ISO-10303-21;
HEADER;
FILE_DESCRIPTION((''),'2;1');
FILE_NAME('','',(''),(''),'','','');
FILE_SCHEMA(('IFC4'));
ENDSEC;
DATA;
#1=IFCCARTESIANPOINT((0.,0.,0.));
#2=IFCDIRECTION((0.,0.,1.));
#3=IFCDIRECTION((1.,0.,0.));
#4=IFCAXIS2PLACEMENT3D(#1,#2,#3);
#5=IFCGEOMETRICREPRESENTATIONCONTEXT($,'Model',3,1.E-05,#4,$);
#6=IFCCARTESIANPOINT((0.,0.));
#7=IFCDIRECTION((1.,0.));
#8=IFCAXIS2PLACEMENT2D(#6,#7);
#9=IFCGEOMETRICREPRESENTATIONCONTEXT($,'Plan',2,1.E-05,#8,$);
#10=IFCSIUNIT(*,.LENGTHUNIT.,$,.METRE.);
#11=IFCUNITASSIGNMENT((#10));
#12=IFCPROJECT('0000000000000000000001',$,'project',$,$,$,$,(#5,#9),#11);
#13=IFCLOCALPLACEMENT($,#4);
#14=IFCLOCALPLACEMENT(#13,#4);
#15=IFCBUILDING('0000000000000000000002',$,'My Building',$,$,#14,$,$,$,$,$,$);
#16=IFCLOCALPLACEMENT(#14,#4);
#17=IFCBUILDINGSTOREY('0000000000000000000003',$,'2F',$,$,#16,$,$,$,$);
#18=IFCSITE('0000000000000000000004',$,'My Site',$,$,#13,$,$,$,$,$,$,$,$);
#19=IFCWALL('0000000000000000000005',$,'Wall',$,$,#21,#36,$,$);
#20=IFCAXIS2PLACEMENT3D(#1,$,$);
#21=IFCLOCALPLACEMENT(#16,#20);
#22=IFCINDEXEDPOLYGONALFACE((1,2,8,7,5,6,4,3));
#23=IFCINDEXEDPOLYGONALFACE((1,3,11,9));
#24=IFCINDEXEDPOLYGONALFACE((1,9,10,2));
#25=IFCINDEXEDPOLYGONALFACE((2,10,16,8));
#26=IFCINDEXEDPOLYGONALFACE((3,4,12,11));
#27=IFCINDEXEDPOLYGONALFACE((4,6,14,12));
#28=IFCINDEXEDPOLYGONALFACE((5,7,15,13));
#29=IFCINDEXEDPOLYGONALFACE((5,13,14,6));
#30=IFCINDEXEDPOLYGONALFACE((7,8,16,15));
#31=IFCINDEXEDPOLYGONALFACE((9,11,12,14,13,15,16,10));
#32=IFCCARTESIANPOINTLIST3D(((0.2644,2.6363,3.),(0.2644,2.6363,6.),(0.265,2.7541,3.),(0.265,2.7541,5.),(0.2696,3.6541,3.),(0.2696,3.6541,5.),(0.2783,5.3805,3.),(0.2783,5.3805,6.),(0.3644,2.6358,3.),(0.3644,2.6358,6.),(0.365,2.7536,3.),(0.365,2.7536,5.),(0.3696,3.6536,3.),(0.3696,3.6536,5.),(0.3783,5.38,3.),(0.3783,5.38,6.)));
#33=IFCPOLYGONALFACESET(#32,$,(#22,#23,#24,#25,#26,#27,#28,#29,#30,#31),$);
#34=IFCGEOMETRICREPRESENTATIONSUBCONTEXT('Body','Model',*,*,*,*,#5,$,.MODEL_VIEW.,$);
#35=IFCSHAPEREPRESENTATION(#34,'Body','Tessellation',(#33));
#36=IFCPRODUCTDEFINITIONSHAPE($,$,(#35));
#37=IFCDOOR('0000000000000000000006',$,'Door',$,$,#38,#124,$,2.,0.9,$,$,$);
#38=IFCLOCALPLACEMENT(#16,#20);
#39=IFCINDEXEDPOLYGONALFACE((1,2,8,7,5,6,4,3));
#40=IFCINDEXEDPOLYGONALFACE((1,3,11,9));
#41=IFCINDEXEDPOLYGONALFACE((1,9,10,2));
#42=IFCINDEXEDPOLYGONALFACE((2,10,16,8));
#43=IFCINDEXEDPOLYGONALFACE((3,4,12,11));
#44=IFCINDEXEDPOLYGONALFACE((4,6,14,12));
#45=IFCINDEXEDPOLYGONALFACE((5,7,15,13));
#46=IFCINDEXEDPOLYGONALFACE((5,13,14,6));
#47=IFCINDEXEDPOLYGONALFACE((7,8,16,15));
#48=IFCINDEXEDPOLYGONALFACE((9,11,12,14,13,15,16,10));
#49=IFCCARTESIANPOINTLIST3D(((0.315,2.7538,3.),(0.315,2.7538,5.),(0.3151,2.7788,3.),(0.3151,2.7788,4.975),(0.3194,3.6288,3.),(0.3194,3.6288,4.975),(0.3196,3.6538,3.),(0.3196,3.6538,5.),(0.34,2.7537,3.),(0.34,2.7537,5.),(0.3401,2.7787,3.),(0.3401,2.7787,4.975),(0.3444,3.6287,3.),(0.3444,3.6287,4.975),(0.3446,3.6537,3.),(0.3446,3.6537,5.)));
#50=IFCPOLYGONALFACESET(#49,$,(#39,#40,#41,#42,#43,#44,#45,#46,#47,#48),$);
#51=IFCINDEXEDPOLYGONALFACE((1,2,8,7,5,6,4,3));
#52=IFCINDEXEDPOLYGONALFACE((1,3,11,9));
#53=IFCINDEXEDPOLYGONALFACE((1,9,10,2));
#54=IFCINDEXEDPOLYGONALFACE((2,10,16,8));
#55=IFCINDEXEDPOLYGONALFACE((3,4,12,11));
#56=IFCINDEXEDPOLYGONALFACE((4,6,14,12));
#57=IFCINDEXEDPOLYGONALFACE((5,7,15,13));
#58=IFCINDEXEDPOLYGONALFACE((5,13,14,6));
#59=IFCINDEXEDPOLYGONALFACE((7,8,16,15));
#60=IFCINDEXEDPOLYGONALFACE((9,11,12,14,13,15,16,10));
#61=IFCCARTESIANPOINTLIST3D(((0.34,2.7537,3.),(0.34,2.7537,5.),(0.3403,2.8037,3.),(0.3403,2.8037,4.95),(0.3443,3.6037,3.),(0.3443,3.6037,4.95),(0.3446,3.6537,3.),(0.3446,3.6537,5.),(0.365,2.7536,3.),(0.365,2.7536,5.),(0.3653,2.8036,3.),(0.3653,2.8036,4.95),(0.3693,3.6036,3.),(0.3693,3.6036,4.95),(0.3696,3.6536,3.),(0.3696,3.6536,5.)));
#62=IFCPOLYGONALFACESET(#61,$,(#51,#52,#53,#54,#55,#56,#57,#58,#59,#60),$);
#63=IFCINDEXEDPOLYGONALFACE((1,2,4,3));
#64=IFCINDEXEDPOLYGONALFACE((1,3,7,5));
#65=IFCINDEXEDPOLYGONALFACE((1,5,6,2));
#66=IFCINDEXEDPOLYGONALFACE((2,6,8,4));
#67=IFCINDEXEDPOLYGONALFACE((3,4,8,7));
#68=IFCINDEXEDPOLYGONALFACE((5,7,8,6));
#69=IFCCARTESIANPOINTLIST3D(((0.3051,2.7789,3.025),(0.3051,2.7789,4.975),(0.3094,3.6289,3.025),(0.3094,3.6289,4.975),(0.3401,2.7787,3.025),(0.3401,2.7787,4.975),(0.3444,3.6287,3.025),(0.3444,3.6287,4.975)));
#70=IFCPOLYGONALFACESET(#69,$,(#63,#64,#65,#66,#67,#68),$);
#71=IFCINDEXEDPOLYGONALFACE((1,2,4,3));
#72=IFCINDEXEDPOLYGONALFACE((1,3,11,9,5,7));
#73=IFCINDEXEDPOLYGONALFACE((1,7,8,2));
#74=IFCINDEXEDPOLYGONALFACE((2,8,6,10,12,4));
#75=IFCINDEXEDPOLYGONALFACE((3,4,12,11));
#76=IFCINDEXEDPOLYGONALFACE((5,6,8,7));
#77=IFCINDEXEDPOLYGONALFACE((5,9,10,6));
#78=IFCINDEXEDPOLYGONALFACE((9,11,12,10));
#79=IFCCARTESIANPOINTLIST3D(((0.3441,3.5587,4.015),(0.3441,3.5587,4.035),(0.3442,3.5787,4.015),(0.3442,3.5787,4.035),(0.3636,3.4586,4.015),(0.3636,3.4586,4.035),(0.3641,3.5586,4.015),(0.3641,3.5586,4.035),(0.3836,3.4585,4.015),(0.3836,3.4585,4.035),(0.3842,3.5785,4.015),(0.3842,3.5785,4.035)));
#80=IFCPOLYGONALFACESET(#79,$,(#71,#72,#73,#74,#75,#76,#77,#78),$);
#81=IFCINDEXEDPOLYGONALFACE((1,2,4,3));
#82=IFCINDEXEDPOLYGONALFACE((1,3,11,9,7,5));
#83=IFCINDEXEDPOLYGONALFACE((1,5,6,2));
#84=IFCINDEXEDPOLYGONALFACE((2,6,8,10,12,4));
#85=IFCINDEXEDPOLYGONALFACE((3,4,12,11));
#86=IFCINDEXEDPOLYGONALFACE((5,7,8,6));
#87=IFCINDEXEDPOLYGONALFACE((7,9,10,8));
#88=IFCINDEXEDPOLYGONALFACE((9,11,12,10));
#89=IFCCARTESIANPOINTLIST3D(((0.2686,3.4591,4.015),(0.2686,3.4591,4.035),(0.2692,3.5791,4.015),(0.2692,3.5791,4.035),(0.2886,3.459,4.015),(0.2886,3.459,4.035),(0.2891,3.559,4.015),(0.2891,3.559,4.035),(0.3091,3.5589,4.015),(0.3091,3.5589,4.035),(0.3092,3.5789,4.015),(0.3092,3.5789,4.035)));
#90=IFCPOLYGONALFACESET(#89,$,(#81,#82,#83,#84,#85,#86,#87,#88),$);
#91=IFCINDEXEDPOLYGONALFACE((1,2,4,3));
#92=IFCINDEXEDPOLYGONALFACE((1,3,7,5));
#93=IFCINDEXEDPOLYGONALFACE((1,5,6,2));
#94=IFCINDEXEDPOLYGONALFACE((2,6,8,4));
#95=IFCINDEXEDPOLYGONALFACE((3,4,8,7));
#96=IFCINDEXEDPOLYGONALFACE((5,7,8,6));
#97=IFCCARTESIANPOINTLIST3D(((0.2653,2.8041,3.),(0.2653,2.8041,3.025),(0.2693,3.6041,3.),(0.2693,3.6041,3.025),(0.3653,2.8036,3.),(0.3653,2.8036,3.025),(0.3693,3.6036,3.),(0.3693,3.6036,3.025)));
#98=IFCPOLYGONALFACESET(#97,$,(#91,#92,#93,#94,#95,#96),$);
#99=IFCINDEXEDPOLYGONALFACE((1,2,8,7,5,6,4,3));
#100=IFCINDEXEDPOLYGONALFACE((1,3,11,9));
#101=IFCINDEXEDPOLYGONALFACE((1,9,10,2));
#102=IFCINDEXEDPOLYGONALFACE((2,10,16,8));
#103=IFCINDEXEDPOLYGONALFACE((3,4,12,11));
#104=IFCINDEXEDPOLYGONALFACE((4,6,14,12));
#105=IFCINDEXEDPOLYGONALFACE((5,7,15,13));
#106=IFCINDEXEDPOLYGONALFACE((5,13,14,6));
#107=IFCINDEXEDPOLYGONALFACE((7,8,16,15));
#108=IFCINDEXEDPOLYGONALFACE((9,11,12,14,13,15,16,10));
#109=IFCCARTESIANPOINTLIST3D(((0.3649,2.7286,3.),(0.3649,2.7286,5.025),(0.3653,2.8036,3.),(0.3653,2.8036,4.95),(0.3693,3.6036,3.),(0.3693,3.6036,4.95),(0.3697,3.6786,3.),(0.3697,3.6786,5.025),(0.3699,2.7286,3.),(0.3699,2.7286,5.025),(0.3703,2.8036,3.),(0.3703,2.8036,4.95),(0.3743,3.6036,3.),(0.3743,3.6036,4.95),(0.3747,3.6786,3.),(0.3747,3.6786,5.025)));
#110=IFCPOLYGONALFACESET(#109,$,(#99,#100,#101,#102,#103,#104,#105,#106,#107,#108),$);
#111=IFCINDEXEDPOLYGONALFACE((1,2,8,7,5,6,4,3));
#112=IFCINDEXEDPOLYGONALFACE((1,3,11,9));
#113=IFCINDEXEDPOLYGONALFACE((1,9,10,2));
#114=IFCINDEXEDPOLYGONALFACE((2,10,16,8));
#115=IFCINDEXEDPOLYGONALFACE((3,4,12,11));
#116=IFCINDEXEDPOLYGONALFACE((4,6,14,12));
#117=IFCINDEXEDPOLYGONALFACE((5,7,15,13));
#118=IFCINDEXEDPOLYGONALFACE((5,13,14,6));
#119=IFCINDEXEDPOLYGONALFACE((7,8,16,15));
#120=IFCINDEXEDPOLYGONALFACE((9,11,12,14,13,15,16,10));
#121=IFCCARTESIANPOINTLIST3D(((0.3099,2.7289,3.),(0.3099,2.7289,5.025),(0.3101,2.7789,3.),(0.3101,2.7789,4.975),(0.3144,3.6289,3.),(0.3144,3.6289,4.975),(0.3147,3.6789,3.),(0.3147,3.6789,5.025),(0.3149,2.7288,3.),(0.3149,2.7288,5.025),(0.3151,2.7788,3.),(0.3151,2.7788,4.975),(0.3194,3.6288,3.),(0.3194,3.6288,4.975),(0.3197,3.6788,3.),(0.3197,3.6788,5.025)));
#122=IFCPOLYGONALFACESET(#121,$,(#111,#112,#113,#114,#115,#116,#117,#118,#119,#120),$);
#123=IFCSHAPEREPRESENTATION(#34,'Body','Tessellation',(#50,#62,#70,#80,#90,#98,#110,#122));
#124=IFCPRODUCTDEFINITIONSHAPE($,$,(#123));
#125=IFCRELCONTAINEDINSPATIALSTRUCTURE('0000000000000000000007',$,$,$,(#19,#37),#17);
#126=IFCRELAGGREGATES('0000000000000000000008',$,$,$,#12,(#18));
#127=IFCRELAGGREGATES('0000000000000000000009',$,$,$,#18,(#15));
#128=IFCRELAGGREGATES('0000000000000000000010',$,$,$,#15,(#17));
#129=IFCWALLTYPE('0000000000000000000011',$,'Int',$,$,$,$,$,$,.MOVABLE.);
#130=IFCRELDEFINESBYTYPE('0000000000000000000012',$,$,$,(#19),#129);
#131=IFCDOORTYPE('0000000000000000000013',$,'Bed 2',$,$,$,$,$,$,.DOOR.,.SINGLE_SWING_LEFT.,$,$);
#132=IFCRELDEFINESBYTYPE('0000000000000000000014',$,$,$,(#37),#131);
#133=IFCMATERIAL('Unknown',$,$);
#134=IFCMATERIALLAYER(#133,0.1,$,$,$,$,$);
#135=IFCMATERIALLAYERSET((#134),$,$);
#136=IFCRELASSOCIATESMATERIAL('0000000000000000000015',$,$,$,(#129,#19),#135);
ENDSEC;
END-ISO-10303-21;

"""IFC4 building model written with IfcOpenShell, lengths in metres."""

from ifc_helpers import new_model, entity, si_unit, frame, origin_with_axes, origin_2d_with_axis, place, context, subcontext, project, spatial, line, indexed_curve, outline, extrude, shape, source, transform, mapped, material, layer, layer_set, layer_usage, type_object, type_shapes, element, fill, save


model = new_model("IFC4")

# Units and contexts
model_context = context("Model", 3, precision=1e-05, world=origin_with_axes())
plan_context = context("Plan", 2, precision=1e-05, world=origin_2d_with_axis())
body_context_1 = subcontext(model_context, "Body", "Model", "MODEL_VIEW")
body_context_2 = subcontext(plan_context, "Body", "Plan", "PLAN_VIEW")
ifc_project = project(units=[si_unit("LENGTHUNIT", "METRE")], contexts=[model_context, plan_context])

# Site, building, storey
site_placement = place(None, origin_with_axes())
site = spatial("IfcSite", under=ifc_project, at=site_placement, Name="My Site")
building_placement = place(site_placement, origin_with_axes())
building = spatial("IfcBuilding", under=site, at=building_placement, Name="My Building")
storey_placement = place(building_placement, origin_with_axes())
storey = spatial("IfcBuildingStorey", under=building, at=storey_placement, Name="2F")

# Shared definitions
ifc_material = material(Name="Unknown")

# Shared definitions
ifc_layer_1 = layer(ifc_material, 0.1)
ifc_layer_set_1 = layer_set([ifc_layer_1])
wall_type_1 = type_object("IfcWallType", Name="Int", PredefinedType="MOVABLE", material=ifc_layer_set_1)

# Wall, opening, door
ifc_layer_usage_1 = layer_usage(ifc_layer_set_1, "AXIS2", "POSITIVE", 0.0)
wall_1_placement = place(storey_placement, frame((0.3644, 2.6358, 3.0), z_axis=(0.0, 0.0, 1.0), x_axis=(0.005081, 0.999987, 0.0)))
wall_1 = element("IfcWall", 1, at=wall_1_placement, inside=storey, type_object=wall_type_1, material=ifc_layer_usage_1, Name="Wall", context=body_context_1, shape_type="SweptSolid", body=[
    extrude(outline(indexed_curve([(0.0, 0.0), (0.0, 0.1), (2.7442, 0.1), (2.7442, 0.0)], segments=[line(1, 2, 3, 4, 1)])), origin_with_axes(), (0.0, 0.0, 1.0), 3.0),
])
shared_shape_1 = source(origin_with_axes(), body_context_1, "Body", "SweptSolid", [
    extrude(outline(indexed_curve([(0.0, 0.0), (0.9, 0.0), (0.9, 2.0), (0.0, 2.0)], segments=[line(1, 2, 3, 4, 1)])), frame((0.0, -0.6, 0.0), z_axis=(0.0, -1.0, 0.0), x_axis=(1.0, 0.0, 0.0)), (0.0, 0.0, -1.0), 1.2),
])
opening_1_placement = place(wall_1_placement, frame((0.1178, 0.0, 0.0), z_axis=(0.0, 0.0, 1.0), x_axis=(1.0, 0.000001, 0.0)))
opening_1 = element("IfcOpeningElement", 2, at=opening_1_placement, cuts=wall_1, PredefinedType="OPENING", context=body_context_1, shape_type="MappedRepresentation", body=[
    mapped(shared_shape_1, transform((0.0, 0.0, 0.0), x_axis=(1.0, 0.0, 0.0), y_axis=(0.0, 1.0, 0.0), z_axis=(0.0, 0.0, 1.0), scale=1.0)),
])
door_type_1 = type_object("IfcDoorType", Name="Bed 2", OperationType="SINGLE_SWING_LEFT", PredefinedType="DOOR")
shared_shape_2 = source(origin_with_axes(), body_context_1, "Body", "SweptSolid", [
    extrude(outline(indexed_curve([(0.0, 0.0), (0.0, 2.0), (0.9, 2.0), (0.9, 0.0), (0.875, 0.0), (0.875, 1.975), (0.025, 1.975), (0.025, 0.0)], segments=[line(1, 2, 3, 4, 5, 6, 7, 8, 1)])), frame((0.0, 0.025, 0.0), z_axis=(0.0, -1.0, 0.0), x_axis=(1.0, 0.0, 0.0)), (0.0, 0.0, -1.0), 0.025),
    extrude(outline(indexed_curve([(0.0, 0.0), (0.0, 2.0), (0.9, 2.0), (0.9, 0.0), (0.85, 0.0), (0.85, 1.95), (0.05, 1.95), (0.05, 0.0)], segments=[line(1, 2, 3, 4, 5, 6, 7, 8, 1)])), frame((0.0, 0.0, 0.0), z_axis=(0.0, -1.0, 0.0), x_axis=(1.0, 0.0, 0.0)), (0.0, 0.0, -1.0), 0.025),
    extrude(outline(indexed_curve([(0.0, 0.0), (0.85, 0.0), (0.85, 0.035), (0.0, 0.035)], segments=[line(1, 2, 3, 4, 1)])), frame((0.025, 0.025, 0.025), z_axis=(0.0, 0.0, 1.0), x_axis=(1.0, 0.0, 0.0)), (0.0, 0.0, 1.0), 1.95),
    extrude(outline(indexed_curve([(0.0, 0.0), (0.0, -0.04), (-0.12, -0.04), (-0.12, -0.02), (-0.02, -0.02), (-0.02, 0.0)], segments=[line(1, 2, 3, 4, 5, 6, 1)])), frame((0.825, 0.025, 1.015), z_axis=(0.0, 0.0, 1.0), x_axis=(1.0, 0.0, 0.0)), (0.0, 0.0, 1.0), 0.02),
    extrude(outline(indexed_curve([(0.0, 0.0), (0.0, 0.04), (-0.12, 0.04), (-0.12, 0.02), (-0.02, 0.02), (-0.02, 0.0)], segments=[line(1, 2, 3, 4, 5, 6, 1)])), frame((0.825, 0.06, 1.015), z_axis=(0.0, 0.0, 1.0), x_axis=(1.0, 0.0, 0.0)), (0.0, 0.0, 1.0), 0.02),
    extrude(outline(indexed_curve([(0.0, 0.0), (0.8, 0.0), (0.8, 0.1), (0.0, 0.1)], segments=[line(1, 2, 3, 4, 1)])), frame((0.05, 0.0, 0.0), z_axis=(0.0, 0.0, 1.0), x_axis=(1.0, 0.0, 0.0)), (0.0, 0.0, 1.0), 0.025),
    extrude(outline(indexed_curve([(0.0, 0.0), (0.0, 2.025), (0.95, 2.025), (0.95, 0.0), (0.875, 0.0), (0.875, 1.95), (0.075, 1.95), (0.075, 0.0)], segments=[line(1, 2, 3, 4, 5, 6, 7, 8, 1)])), frame((-0.025, -0.005, 0.0), z_axis=(0.0, -1.0, 0.0), x_axis=(1.0, 0.0, 0.0)), (0.0, 0.0, -1.0), 0.005),
    extrude(outline(indexed_curve([(0.0, 0.0), (0.0, 2.025), (0.95, 2.025), (0.95, 0.0), (0.9, 0.0), (0.9, 1.975), (0.05, 1.975), (0.05, 0.0)], segments=[line(1, 2, 3, 4, 5, 6, 7, 8, 1)])), frame((-0.025, 0.05, 0.0), z_axis=(0.0, -1.0, 0.0), x_axis=(1.0, 0.0, 0.0)), (0.0, 0.0, -1.0), 0.005),
])
shared_shape_3 = source(origin_with_axes(), body_context_2, "Body", "Curve2D", [
    entity("IfcIndexedPolyCurve", entity("IfcCartesianPointList2D", [[0.0, 0.0], [0.0, 0.05], [0.025, 0.05], [0.025, 0.025], [0.05, 0.025], [0.05, 0.0]]), [entity("IfcLineIndex", [1, 2, 3, 4, 5, 6, 1])]),
    entity("IfcIndexedPolyCurve", entity("IfcCartesianPointList2D", [[0.9, 0.0], [0.9, 0.05], [0.875, 0.05], [0.875, 0.025], [0.85, 0.025], [0.85, 0.0]]), [entity("IfcLineIndex", [1, 2, 3, 4, 5, 6, 1])]),
    entity("IfcTrimmedCurve", entity("IfcEllipse", entity("IfcAxis2Placement2D", entity("IfcCartesianPoint", [0.06, 0.05]), entity("IfcDirection", [1.0, 0.0])), 0.815, 0.85), [entity("IfcCartesianPoint", [0.875, 0.05])], [entity("IfcCartesianPoint", [0.06, 0.9])], True, "CARTESIAN"),
    entity("IfcIndexedPolyCurve", entity("IfcCartesianPointList2D", [[0.025, 0.05], [0.06, 0.05], [0.06, 0.9], [0.025, 0.9]]), [entity("IfcLineIndex", [1, 2, 3, 4, 1])]),
])
type_shapes(door_type_1, [shared_shape_2, shared_shape_3])
door_1_placement = place(opening_1_placement, frame((0.0, 0.0, 0.0), z_axis=(0.0, 0.0, 1.0), x_axis=(1.0, 0.0, 0.0)))
door_1 = element("IfcDoor", 3, at=door_1_placement, inside=storey, type_object=door_type_1, Name="Door", OverallHeight=2.0, OverallWidth=0.9, shapes=[
    shape(body_context_1, "Body", "MappedRepresentation", [mapped(shared_shape_2, transform((0.0, 0.0, 0.0), x_axis=(1.0, 0.0, 0.0), y_axis=(0.0, 1.0, 0.0), z_axis=(0.0, 0.0, 1.0), scale=1.0))]),
    shape(body_context_2, "Body", "MappedRepresentation", [mapped(shared_shape_3, transform((0.0, 0.0, 0.0), x_axis=(1.0, 0.0, 0.0), y_axis=(0.0, 1.0, 0.0), z_axis=(0.0, 0.0, 1.0), scale=1.0))]),
])
fill(opening_1, door_1)

save(model, "model.ifc")
